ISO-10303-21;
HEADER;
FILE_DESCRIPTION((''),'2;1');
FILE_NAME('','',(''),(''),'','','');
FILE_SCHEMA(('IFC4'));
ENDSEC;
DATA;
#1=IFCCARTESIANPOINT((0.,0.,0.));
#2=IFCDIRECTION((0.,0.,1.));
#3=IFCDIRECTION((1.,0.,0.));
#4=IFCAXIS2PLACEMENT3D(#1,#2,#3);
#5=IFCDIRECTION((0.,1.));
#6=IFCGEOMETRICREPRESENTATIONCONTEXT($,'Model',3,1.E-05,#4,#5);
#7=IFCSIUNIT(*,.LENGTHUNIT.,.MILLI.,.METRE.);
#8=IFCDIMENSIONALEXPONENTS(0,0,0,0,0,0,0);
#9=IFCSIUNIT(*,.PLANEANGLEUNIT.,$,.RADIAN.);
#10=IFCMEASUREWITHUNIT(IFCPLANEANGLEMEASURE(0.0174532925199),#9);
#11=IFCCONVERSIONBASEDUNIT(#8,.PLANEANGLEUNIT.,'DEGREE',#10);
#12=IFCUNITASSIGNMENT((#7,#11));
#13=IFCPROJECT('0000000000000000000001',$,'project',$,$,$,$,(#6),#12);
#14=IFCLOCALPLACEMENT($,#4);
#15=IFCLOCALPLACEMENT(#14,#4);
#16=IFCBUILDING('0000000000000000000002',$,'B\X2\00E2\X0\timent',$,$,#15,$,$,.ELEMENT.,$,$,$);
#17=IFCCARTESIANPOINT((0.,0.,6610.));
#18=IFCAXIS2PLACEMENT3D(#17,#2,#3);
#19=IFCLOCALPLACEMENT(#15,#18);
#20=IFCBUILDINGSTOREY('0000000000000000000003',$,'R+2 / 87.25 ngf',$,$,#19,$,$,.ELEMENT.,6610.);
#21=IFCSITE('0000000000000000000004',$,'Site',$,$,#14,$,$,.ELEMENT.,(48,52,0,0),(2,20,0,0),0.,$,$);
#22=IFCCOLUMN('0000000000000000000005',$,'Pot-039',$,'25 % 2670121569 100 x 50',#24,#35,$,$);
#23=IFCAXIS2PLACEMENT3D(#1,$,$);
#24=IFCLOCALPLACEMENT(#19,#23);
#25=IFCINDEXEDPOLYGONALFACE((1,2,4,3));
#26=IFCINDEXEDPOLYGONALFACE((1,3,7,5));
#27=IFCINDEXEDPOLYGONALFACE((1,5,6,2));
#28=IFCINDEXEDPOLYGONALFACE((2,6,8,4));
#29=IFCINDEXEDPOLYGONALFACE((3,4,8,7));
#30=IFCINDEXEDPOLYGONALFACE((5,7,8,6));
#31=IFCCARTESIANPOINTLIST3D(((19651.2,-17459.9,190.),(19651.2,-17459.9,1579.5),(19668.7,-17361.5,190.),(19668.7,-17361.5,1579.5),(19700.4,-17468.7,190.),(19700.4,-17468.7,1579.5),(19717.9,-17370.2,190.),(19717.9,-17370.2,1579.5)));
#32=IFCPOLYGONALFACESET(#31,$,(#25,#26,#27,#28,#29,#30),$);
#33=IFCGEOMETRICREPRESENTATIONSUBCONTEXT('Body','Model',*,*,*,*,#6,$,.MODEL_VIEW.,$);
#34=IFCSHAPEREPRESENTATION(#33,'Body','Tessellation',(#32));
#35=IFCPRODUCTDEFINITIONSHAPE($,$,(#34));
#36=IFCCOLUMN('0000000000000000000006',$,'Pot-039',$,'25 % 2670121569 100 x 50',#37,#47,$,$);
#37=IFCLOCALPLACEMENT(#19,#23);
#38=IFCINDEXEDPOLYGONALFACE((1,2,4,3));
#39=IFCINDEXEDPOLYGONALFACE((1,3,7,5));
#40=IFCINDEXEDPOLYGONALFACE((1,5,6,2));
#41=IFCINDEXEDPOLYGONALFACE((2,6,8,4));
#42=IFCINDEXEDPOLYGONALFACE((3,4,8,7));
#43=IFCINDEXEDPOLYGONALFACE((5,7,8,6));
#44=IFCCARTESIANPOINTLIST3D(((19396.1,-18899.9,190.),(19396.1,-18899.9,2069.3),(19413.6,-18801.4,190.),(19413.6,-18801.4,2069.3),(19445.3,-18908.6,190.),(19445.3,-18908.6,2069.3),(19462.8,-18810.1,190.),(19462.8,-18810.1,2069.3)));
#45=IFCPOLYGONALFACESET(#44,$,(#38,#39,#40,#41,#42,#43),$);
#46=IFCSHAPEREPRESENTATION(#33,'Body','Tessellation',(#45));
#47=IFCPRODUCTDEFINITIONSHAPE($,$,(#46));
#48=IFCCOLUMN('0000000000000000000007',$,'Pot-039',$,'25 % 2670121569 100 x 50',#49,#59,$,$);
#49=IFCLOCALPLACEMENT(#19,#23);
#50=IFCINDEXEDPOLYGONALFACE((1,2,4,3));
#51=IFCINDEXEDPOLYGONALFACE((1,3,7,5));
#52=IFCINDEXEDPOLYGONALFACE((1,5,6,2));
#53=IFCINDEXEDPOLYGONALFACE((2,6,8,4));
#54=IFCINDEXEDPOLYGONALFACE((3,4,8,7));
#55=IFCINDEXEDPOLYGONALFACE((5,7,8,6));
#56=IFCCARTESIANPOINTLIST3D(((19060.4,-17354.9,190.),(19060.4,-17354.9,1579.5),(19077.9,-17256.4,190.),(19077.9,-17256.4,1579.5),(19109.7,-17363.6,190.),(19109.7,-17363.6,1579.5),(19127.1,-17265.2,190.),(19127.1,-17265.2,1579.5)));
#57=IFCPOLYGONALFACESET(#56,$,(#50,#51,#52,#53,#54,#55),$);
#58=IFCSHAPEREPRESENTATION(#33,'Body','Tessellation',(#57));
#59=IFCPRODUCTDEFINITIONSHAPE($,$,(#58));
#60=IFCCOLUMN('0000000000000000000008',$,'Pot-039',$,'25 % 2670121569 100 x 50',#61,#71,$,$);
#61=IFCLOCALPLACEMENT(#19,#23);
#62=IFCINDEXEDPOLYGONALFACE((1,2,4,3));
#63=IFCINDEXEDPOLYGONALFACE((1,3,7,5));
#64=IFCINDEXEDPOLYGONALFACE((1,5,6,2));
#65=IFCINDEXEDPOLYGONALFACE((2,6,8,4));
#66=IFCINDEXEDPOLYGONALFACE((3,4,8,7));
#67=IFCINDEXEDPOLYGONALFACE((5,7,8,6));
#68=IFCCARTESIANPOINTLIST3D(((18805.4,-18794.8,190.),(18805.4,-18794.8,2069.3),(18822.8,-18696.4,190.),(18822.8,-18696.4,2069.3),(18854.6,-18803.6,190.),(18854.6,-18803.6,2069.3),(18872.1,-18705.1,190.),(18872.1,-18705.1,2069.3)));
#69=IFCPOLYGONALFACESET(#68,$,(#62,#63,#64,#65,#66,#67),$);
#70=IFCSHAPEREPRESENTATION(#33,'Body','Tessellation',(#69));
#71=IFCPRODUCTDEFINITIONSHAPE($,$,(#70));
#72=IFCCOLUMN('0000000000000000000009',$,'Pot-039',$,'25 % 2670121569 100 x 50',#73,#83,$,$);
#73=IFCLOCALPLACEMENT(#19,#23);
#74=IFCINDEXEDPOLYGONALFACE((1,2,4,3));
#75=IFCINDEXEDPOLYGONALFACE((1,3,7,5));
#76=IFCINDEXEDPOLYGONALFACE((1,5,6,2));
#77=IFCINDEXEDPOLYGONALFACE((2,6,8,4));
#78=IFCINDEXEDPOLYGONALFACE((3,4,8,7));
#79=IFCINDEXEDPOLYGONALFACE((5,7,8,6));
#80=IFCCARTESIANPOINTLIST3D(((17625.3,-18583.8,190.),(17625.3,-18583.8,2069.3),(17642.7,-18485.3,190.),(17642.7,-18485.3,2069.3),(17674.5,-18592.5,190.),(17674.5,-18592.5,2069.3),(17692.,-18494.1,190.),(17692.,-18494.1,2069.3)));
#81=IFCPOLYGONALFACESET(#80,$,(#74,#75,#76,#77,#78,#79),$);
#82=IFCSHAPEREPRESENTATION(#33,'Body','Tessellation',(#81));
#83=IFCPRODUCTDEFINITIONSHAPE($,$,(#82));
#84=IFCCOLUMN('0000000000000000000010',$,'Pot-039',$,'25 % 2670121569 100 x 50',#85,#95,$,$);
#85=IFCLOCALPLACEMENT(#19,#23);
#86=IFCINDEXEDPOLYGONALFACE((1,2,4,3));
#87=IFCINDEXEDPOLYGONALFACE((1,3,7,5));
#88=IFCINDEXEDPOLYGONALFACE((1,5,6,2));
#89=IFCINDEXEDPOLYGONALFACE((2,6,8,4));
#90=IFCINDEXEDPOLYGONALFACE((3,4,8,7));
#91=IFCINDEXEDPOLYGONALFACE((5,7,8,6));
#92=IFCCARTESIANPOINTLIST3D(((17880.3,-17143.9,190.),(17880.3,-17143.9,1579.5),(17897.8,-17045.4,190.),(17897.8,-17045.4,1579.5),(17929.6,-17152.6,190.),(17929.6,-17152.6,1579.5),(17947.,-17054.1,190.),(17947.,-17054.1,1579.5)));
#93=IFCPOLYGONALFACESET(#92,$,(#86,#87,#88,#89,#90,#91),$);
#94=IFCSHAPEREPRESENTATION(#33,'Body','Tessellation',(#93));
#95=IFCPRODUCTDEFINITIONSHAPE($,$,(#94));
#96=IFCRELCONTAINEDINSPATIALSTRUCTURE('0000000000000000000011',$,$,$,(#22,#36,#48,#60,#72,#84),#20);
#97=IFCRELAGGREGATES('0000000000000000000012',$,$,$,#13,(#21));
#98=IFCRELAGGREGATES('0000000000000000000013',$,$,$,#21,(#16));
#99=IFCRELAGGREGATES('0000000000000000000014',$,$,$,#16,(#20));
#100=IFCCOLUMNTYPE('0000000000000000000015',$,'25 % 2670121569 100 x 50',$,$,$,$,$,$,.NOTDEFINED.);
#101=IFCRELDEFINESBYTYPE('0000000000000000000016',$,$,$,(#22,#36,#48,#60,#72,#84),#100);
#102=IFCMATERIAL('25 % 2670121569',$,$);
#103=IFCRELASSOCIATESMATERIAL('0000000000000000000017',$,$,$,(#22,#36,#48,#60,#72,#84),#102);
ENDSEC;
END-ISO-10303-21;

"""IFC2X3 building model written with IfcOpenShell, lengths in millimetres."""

from ifc_helpers import new_model, entity, si_unit, converted_unit, direction, frame, origin_with_axes, origin_2d_with_axis, place, context, subcontext, project, spatial, rectangle, extrude, material, type_object, element, save


model = new_model("IFC2X3")

# Units and contexts
model_context = context("Model", 3, precision=1e-05, world=origin_with_axes(), true_north=direction((0.0, 1.0)))
body_context = subcontext(model_context, "Body", "Model", "MODEL_VIEW")
ifc_project = project(units=[si_unit("LENGTHUNIT", "METRE", prefix="MILLI"), converted_unit("PLANEANGLEUNIT", "DEGREE", entity("IfcPlaneAngleMeasure", 0.0174532925199), si_unit("PLANEANGLEUNIT", "RADIAN"), dimensions=[0, 0, 0, 0, 0, 0, 0])], contexts=[model_context])

# Site, building, storey
site_placement = place(None, origin_with_axes())
site = spatial("IfcSite", under=ifc_project, at=site_placement, Name="Site", CompositionType="ELEMENT", RefLatitude=(48, 52, 0, 0), RefLongitude=(2, 20, 0, 0), RefElevation=0.0)
building_placement = place(site_placement, origin_with_axes())
building = spatial("IfcBuilding", under=site, at=building_placement, Name="Bâtiment", CompositionType="ELEMENT")
storey_placement = place(building_placement, frame((0.0, 0.0, 6610.0), z_axis=(0.0, 0.0, 1.0), x_axis=(1.0, 0.0, 0.0)))
storey = spatial("IfcBuildingStorey", under=building, at=storey_placement, Name="R+2 / 87.25 ngf", CompositionType="ELEMENT", Elevation=6610.0)

# Columns
ifc_material_1 = material(Name="25 % 2670121569")
column_type = type_object("IfcColumnType", Name="25 % 2670121569 100 x 50", PredefinedType="NOTDEFINED")
column_1_placement = place(storey_placement, frame((19684.5, -17415.1, 190.0), z_axis=(0.0, 0.0, 1.0), x_axis=(0.17478, 0.984607, 0.0)))
element("IfcColumn", 1, at=column_1_placement, inside=storey, type_object=column_type, material=ifc_material_1, Name="Pot-039", ObjectType="25 % 2670121569 100 x 50", context=body_context, shape_type="SweptSolid", body=[
    extrude(rectangle(XDim=100.0, YDim=50.0, at=origin_2d_with_axis()), origin_with_axes(), (0.0, 0.0, 1.0), 1389.5),
])
column_2_placement = place(storey_placement, frame((19429.5, -18855.0, 190.0), z_axis=(0.0, 0.0, 1.0), x_axis=(0.17478, 0.984607, 0.0)))
element("IfcColumn", 2, at=column_2_placement, inside=storey, type_object=column_type, material=ifc_material_1, Name="Pot-039", ObjectType="25 % 2670121569 100 x 50", context=body_context, shape_type="SweptSolid", body=[
    extrude(rectangle(XDim=100.0, YDim=50.0, at=origin_2d_with_axis()), origin_with_axes(), (0.0, 0.0, 1.0), 1879.3),
])
column_3_placement = place(storey_placement, frame((19093.8, -17310.0, 190.0), z_axis=(0.0, 0.0, 1.0), x_axis=(0.17478, 0.984607, 0.0)))
element("IfcColumn", 3, at=column_3_placement, inside=storey, type_object=column_type, material=ifc_material_1, Name="Pot-039", ObjectType="25 % 2670121569 100 x 50", context=body_context, shape_type="SweptSolid", body=[
    extrude(rectangle(XDim=100.0, YDim=50.0, at=origin_2d_with_axis()), origin_with_axes(), (0.0, 0.0, 1.0), 1389.5),
])
for number, where, z_axis, x_axis, name in (
    (4, (18838.7, -18750.0, 190.0), (0.0, 0.0, 1.0), (0.17478, 0.984607, 0.0), "Pot-039"),
    (5, (17658.6, -18538.9, 190.0), (0.0, 0.0, 1.0), (0.17478, 0.984607, 0.0), "Pot-039"),
):
    element("IfcColumn", number, at=place(storey_placement, frame(where, z_axis=z_axis, x_axis=x_axis)), inside=storey, type_object=column_type, material=ifc_material_1, Name=name, ObjectType="25 % 2670121569 100 x 50", context=body_context, shape_type="SweptSolid", body=[
        extrude(rectangle(XDim=100.0, YDim=50.0, at=origin_2d_with_axis()), origin_with_axes(), (0.0, 0.0, 1.0), 1879.3),
    ])
column_4_placement = place(storey_placement, frame((17913.7, -17099.0, 190.0), z_axis=(0.0, 0.0, 1.0), x_axis=(0.17478, 0.984607, 0.0)))
element("IfcColumn", 6, at=column_4_placement, inside=storey, type_object=column_type, material=ifc_material_1, Name="Pot-039", ObjectType="25 % 2670121569 100 x 50", context=body_context, shape_type="SweptSolid", body=[
    extrude(rectangle(XDim=100.0, YDim=50.0, at=origin_2d_with_axis()), origin_with_axes(), (0.0, 0.0, 1.0), 1389.5),
])

save(model, "model.ifc")
